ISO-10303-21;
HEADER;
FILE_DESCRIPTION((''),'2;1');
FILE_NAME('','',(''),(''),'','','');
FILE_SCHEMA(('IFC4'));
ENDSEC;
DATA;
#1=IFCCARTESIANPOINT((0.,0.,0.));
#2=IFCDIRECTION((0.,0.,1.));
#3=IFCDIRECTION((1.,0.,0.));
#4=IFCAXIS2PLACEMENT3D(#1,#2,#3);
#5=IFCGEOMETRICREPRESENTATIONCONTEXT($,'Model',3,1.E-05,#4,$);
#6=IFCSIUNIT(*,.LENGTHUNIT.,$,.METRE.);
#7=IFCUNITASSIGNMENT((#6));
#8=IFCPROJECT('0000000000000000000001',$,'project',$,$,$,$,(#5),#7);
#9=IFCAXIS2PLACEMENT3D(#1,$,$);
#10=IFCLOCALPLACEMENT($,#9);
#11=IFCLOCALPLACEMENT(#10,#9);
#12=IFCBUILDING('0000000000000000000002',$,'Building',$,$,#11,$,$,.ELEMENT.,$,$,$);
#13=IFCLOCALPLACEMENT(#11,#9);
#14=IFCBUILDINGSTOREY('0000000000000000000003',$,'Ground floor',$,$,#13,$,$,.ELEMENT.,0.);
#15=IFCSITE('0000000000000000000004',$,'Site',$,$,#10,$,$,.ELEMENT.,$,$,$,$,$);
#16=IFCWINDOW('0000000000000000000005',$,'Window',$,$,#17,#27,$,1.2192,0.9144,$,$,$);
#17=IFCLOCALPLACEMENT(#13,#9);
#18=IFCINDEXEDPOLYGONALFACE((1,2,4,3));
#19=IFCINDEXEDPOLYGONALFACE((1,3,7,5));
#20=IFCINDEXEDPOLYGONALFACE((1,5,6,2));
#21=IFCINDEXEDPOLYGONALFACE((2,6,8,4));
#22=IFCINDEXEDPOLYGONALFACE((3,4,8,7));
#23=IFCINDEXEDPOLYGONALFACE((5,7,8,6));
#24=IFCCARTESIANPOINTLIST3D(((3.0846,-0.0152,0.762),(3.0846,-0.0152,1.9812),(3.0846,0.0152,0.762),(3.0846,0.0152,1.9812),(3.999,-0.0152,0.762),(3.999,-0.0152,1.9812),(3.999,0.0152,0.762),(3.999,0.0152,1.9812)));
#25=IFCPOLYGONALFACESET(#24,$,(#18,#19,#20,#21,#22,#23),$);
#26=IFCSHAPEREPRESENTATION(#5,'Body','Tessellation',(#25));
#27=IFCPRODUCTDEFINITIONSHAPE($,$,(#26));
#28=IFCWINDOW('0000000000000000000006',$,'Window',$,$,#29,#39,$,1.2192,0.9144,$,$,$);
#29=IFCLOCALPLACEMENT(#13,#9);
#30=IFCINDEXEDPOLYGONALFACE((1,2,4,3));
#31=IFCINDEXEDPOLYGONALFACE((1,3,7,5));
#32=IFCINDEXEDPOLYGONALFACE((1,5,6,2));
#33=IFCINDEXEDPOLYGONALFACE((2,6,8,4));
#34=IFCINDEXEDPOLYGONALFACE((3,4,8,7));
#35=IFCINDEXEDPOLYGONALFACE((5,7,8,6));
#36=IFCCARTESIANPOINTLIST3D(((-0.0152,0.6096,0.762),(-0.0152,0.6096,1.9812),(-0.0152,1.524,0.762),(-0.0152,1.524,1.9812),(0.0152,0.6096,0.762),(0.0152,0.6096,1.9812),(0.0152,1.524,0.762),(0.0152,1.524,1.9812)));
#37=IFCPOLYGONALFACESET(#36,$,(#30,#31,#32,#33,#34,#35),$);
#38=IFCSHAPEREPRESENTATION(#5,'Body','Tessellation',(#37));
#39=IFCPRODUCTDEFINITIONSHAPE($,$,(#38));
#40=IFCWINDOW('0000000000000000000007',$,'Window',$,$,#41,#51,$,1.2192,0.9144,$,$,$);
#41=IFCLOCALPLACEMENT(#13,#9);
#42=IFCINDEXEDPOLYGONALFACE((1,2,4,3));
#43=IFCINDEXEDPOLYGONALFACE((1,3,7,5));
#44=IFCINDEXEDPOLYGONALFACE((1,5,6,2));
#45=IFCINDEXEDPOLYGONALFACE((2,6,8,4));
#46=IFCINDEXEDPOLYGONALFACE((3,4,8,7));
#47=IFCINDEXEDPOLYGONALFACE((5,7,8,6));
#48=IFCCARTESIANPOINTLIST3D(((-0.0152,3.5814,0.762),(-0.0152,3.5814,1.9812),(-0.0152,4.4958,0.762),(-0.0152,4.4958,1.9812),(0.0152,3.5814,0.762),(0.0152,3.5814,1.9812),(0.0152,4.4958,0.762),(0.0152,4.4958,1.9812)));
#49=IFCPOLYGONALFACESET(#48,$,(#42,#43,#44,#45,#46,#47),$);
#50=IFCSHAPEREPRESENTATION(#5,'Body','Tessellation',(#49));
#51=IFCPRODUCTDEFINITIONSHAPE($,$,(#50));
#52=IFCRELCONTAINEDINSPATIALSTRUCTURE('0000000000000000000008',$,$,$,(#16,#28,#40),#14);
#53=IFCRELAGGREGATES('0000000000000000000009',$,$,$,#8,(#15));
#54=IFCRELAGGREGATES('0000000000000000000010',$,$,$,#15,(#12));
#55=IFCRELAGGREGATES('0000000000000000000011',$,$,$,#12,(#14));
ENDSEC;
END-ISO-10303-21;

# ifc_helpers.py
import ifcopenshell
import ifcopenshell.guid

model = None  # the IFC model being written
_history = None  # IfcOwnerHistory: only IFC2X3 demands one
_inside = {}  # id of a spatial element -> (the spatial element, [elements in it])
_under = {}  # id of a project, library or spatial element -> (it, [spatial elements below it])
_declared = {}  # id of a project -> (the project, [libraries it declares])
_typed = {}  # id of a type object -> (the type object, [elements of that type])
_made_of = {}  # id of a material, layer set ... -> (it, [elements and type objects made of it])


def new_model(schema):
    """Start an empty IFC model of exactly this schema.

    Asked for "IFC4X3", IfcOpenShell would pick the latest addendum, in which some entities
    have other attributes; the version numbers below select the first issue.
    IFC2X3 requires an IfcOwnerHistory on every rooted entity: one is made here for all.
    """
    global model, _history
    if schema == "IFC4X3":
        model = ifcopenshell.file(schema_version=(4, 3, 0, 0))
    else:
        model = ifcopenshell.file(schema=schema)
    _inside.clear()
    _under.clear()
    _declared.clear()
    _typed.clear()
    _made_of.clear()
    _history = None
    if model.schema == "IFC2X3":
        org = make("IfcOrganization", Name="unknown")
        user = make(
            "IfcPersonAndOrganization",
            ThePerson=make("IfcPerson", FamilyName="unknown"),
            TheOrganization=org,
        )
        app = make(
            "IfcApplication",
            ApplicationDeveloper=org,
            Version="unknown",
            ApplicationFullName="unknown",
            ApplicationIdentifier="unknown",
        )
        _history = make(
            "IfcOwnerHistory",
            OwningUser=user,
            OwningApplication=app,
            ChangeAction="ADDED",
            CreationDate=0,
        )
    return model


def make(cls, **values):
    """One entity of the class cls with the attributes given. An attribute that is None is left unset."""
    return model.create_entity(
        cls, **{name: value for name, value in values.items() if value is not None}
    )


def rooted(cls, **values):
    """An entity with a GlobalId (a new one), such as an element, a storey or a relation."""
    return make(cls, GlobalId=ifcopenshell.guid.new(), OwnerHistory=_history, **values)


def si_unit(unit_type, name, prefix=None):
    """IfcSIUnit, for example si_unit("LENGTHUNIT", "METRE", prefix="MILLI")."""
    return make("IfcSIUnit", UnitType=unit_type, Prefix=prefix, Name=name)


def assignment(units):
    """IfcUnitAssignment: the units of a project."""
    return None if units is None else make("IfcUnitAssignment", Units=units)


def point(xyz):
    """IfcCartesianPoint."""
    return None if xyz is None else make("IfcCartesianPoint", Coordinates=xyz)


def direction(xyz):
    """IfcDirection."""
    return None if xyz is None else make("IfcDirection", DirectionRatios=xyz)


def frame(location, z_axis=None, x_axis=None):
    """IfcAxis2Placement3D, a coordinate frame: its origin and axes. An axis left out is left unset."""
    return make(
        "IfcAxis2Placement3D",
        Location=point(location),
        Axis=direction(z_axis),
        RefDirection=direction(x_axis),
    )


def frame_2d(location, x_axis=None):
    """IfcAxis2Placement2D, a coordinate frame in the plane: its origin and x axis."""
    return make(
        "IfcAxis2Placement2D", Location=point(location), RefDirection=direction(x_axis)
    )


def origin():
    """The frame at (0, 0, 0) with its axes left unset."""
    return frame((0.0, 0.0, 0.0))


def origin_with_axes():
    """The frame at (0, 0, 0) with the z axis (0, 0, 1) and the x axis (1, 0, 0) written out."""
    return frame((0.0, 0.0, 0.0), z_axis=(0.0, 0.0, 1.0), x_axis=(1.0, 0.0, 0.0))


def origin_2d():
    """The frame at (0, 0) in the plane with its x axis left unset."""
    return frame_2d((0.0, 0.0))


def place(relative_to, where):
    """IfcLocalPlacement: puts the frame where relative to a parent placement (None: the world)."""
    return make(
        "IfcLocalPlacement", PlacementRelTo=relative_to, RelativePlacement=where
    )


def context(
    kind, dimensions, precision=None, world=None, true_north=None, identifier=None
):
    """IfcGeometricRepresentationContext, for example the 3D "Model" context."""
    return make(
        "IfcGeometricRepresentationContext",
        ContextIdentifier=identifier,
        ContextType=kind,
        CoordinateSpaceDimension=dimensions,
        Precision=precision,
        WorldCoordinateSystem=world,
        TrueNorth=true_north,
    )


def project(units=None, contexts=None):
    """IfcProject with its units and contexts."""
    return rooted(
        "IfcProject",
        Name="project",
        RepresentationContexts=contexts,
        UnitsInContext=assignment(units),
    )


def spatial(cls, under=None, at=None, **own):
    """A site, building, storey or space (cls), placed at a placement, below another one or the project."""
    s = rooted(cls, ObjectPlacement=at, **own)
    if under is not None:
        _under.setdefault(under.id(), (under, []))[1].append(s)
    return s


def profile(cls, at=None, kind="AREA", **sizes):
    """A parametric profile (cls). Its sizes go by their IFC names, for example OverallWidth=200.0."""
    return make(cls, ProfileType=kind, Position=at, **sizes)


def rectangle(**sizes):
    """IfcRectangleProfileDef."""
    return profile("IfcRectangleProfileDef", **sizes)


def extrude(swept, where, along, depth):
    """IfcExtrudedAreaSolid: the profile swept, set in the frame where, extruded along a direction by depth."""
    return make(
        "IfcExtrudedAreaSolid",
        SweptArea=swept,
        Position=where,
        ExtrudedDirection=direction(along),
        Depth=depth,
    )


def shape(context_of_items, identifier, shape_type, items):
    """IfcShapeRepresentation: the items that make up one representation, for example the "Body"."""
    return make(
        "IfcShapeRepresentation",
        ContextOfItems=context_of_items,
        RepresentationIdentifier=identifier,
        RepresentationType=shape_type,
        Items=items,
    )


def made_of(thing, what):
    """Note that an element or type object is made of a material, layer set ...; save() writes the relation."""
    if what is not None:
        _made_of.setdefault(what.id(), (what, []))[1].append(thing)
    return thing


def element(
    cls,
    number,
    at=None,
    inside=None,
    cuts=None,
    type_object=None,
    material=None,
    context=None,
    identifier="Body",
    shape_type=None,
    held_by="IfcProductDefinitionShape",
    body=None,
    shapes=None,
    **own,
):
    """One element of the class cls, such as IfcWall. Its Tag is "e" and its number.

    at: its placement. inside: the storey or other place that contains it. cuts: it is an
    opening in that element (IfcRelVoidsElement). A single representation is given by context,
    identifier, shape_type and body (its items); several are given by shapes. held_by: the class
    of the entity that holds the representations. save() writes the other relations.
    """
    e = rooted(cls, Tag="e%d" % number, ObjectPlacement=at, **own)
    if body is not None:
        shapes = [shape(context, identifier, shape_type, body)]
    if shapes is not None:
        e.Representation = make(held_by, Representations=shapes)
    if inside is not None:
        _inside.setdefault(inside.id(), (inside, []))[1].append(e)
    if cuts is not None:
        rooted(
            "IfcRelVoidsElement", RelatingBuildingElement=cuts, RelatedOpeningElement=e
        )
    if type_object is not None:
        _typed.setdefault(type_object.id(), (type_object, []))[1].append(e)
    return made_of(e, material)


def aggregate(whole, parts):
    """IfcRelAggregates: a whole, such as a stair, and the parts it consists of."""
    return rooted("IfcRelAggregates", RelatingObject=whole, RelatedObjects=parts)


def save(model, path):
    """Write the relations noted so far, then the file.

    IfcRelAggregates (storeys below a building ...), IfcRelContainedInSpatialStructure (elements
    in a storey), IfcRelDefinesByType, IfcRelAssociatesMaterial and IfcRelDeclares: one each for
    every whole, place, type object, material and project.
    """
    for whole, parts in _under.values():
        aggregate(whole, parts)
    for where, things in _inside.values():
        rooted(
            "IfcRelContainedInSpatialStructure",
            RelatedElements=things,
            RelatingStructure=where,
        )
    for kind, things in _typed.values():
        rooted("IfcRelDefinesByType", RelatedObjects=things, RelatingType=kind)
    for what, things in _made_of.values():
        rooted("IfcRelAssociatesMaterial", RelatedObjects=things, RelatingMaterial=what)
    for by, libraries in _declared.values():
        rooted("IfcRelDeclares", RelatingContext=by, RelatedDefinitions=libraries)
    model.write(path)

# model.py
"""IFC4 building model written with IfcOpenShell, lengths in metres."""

from ifc_helpers import new_model, si_unit, frame, origin, origin_with_axes, origin_2d, place, context, project, spatial, rectangle, extrude, element, save


model = new_model("IFC4")

# Units and contexts
model_context = context("Model", 3, precision=1e-05, world=origin_with_axes())
ifc_project = project(units=[si_unit("LENGTHUNIT", "METRE")], contexts=[model_context])

# Site, building, storey
site_placement = place(None, origin())
site = spatial("IfcSite", under=ifc_project, at=site_placement, Name="Site", CompositionType="ELEMENT")
building_placement = place(site_placement, origin())
building = spatial("IfcBuilding", under=site, at=building_placement, Name="Building", CompositionType="ELEMENT")
storey_placement = place(building_placement, origin())
storey = spatial("IfcBuildingStorey", under=building, at=storey_placement, Name="Ground floor", CompositionType="ELEMENT", Elevation=0.0)

# Windows
for number, where, x_axis, name in (
    (1, (3.5418, 0.0, 0.762), (1.0, 0.0, 0.0), "Window"),
    (2, (0.0, 1.0668, 0.762), (0.0, 1.0, 0.0), "Window"),
    (3, (0.0, 4.0386, 0.762), (0.0, 1.0, 0.0), "Window"),
):
    element("IfcWindow", number, at=place(storey_placement, frame(where, x_axis=x_axis)), inside=storey, Name=name, OverallHeight=1.2192, OverallWidth=0.9144, context=model_context, shape_type="SweptSolid", body=[
        extrude(rectangle(XDim=0.9144, YDim=0.0305, at=origin_2d()), origin(), (0.0, 0.0, 1.0), 1.2192),
    ])

save(model, "model.ifc")
